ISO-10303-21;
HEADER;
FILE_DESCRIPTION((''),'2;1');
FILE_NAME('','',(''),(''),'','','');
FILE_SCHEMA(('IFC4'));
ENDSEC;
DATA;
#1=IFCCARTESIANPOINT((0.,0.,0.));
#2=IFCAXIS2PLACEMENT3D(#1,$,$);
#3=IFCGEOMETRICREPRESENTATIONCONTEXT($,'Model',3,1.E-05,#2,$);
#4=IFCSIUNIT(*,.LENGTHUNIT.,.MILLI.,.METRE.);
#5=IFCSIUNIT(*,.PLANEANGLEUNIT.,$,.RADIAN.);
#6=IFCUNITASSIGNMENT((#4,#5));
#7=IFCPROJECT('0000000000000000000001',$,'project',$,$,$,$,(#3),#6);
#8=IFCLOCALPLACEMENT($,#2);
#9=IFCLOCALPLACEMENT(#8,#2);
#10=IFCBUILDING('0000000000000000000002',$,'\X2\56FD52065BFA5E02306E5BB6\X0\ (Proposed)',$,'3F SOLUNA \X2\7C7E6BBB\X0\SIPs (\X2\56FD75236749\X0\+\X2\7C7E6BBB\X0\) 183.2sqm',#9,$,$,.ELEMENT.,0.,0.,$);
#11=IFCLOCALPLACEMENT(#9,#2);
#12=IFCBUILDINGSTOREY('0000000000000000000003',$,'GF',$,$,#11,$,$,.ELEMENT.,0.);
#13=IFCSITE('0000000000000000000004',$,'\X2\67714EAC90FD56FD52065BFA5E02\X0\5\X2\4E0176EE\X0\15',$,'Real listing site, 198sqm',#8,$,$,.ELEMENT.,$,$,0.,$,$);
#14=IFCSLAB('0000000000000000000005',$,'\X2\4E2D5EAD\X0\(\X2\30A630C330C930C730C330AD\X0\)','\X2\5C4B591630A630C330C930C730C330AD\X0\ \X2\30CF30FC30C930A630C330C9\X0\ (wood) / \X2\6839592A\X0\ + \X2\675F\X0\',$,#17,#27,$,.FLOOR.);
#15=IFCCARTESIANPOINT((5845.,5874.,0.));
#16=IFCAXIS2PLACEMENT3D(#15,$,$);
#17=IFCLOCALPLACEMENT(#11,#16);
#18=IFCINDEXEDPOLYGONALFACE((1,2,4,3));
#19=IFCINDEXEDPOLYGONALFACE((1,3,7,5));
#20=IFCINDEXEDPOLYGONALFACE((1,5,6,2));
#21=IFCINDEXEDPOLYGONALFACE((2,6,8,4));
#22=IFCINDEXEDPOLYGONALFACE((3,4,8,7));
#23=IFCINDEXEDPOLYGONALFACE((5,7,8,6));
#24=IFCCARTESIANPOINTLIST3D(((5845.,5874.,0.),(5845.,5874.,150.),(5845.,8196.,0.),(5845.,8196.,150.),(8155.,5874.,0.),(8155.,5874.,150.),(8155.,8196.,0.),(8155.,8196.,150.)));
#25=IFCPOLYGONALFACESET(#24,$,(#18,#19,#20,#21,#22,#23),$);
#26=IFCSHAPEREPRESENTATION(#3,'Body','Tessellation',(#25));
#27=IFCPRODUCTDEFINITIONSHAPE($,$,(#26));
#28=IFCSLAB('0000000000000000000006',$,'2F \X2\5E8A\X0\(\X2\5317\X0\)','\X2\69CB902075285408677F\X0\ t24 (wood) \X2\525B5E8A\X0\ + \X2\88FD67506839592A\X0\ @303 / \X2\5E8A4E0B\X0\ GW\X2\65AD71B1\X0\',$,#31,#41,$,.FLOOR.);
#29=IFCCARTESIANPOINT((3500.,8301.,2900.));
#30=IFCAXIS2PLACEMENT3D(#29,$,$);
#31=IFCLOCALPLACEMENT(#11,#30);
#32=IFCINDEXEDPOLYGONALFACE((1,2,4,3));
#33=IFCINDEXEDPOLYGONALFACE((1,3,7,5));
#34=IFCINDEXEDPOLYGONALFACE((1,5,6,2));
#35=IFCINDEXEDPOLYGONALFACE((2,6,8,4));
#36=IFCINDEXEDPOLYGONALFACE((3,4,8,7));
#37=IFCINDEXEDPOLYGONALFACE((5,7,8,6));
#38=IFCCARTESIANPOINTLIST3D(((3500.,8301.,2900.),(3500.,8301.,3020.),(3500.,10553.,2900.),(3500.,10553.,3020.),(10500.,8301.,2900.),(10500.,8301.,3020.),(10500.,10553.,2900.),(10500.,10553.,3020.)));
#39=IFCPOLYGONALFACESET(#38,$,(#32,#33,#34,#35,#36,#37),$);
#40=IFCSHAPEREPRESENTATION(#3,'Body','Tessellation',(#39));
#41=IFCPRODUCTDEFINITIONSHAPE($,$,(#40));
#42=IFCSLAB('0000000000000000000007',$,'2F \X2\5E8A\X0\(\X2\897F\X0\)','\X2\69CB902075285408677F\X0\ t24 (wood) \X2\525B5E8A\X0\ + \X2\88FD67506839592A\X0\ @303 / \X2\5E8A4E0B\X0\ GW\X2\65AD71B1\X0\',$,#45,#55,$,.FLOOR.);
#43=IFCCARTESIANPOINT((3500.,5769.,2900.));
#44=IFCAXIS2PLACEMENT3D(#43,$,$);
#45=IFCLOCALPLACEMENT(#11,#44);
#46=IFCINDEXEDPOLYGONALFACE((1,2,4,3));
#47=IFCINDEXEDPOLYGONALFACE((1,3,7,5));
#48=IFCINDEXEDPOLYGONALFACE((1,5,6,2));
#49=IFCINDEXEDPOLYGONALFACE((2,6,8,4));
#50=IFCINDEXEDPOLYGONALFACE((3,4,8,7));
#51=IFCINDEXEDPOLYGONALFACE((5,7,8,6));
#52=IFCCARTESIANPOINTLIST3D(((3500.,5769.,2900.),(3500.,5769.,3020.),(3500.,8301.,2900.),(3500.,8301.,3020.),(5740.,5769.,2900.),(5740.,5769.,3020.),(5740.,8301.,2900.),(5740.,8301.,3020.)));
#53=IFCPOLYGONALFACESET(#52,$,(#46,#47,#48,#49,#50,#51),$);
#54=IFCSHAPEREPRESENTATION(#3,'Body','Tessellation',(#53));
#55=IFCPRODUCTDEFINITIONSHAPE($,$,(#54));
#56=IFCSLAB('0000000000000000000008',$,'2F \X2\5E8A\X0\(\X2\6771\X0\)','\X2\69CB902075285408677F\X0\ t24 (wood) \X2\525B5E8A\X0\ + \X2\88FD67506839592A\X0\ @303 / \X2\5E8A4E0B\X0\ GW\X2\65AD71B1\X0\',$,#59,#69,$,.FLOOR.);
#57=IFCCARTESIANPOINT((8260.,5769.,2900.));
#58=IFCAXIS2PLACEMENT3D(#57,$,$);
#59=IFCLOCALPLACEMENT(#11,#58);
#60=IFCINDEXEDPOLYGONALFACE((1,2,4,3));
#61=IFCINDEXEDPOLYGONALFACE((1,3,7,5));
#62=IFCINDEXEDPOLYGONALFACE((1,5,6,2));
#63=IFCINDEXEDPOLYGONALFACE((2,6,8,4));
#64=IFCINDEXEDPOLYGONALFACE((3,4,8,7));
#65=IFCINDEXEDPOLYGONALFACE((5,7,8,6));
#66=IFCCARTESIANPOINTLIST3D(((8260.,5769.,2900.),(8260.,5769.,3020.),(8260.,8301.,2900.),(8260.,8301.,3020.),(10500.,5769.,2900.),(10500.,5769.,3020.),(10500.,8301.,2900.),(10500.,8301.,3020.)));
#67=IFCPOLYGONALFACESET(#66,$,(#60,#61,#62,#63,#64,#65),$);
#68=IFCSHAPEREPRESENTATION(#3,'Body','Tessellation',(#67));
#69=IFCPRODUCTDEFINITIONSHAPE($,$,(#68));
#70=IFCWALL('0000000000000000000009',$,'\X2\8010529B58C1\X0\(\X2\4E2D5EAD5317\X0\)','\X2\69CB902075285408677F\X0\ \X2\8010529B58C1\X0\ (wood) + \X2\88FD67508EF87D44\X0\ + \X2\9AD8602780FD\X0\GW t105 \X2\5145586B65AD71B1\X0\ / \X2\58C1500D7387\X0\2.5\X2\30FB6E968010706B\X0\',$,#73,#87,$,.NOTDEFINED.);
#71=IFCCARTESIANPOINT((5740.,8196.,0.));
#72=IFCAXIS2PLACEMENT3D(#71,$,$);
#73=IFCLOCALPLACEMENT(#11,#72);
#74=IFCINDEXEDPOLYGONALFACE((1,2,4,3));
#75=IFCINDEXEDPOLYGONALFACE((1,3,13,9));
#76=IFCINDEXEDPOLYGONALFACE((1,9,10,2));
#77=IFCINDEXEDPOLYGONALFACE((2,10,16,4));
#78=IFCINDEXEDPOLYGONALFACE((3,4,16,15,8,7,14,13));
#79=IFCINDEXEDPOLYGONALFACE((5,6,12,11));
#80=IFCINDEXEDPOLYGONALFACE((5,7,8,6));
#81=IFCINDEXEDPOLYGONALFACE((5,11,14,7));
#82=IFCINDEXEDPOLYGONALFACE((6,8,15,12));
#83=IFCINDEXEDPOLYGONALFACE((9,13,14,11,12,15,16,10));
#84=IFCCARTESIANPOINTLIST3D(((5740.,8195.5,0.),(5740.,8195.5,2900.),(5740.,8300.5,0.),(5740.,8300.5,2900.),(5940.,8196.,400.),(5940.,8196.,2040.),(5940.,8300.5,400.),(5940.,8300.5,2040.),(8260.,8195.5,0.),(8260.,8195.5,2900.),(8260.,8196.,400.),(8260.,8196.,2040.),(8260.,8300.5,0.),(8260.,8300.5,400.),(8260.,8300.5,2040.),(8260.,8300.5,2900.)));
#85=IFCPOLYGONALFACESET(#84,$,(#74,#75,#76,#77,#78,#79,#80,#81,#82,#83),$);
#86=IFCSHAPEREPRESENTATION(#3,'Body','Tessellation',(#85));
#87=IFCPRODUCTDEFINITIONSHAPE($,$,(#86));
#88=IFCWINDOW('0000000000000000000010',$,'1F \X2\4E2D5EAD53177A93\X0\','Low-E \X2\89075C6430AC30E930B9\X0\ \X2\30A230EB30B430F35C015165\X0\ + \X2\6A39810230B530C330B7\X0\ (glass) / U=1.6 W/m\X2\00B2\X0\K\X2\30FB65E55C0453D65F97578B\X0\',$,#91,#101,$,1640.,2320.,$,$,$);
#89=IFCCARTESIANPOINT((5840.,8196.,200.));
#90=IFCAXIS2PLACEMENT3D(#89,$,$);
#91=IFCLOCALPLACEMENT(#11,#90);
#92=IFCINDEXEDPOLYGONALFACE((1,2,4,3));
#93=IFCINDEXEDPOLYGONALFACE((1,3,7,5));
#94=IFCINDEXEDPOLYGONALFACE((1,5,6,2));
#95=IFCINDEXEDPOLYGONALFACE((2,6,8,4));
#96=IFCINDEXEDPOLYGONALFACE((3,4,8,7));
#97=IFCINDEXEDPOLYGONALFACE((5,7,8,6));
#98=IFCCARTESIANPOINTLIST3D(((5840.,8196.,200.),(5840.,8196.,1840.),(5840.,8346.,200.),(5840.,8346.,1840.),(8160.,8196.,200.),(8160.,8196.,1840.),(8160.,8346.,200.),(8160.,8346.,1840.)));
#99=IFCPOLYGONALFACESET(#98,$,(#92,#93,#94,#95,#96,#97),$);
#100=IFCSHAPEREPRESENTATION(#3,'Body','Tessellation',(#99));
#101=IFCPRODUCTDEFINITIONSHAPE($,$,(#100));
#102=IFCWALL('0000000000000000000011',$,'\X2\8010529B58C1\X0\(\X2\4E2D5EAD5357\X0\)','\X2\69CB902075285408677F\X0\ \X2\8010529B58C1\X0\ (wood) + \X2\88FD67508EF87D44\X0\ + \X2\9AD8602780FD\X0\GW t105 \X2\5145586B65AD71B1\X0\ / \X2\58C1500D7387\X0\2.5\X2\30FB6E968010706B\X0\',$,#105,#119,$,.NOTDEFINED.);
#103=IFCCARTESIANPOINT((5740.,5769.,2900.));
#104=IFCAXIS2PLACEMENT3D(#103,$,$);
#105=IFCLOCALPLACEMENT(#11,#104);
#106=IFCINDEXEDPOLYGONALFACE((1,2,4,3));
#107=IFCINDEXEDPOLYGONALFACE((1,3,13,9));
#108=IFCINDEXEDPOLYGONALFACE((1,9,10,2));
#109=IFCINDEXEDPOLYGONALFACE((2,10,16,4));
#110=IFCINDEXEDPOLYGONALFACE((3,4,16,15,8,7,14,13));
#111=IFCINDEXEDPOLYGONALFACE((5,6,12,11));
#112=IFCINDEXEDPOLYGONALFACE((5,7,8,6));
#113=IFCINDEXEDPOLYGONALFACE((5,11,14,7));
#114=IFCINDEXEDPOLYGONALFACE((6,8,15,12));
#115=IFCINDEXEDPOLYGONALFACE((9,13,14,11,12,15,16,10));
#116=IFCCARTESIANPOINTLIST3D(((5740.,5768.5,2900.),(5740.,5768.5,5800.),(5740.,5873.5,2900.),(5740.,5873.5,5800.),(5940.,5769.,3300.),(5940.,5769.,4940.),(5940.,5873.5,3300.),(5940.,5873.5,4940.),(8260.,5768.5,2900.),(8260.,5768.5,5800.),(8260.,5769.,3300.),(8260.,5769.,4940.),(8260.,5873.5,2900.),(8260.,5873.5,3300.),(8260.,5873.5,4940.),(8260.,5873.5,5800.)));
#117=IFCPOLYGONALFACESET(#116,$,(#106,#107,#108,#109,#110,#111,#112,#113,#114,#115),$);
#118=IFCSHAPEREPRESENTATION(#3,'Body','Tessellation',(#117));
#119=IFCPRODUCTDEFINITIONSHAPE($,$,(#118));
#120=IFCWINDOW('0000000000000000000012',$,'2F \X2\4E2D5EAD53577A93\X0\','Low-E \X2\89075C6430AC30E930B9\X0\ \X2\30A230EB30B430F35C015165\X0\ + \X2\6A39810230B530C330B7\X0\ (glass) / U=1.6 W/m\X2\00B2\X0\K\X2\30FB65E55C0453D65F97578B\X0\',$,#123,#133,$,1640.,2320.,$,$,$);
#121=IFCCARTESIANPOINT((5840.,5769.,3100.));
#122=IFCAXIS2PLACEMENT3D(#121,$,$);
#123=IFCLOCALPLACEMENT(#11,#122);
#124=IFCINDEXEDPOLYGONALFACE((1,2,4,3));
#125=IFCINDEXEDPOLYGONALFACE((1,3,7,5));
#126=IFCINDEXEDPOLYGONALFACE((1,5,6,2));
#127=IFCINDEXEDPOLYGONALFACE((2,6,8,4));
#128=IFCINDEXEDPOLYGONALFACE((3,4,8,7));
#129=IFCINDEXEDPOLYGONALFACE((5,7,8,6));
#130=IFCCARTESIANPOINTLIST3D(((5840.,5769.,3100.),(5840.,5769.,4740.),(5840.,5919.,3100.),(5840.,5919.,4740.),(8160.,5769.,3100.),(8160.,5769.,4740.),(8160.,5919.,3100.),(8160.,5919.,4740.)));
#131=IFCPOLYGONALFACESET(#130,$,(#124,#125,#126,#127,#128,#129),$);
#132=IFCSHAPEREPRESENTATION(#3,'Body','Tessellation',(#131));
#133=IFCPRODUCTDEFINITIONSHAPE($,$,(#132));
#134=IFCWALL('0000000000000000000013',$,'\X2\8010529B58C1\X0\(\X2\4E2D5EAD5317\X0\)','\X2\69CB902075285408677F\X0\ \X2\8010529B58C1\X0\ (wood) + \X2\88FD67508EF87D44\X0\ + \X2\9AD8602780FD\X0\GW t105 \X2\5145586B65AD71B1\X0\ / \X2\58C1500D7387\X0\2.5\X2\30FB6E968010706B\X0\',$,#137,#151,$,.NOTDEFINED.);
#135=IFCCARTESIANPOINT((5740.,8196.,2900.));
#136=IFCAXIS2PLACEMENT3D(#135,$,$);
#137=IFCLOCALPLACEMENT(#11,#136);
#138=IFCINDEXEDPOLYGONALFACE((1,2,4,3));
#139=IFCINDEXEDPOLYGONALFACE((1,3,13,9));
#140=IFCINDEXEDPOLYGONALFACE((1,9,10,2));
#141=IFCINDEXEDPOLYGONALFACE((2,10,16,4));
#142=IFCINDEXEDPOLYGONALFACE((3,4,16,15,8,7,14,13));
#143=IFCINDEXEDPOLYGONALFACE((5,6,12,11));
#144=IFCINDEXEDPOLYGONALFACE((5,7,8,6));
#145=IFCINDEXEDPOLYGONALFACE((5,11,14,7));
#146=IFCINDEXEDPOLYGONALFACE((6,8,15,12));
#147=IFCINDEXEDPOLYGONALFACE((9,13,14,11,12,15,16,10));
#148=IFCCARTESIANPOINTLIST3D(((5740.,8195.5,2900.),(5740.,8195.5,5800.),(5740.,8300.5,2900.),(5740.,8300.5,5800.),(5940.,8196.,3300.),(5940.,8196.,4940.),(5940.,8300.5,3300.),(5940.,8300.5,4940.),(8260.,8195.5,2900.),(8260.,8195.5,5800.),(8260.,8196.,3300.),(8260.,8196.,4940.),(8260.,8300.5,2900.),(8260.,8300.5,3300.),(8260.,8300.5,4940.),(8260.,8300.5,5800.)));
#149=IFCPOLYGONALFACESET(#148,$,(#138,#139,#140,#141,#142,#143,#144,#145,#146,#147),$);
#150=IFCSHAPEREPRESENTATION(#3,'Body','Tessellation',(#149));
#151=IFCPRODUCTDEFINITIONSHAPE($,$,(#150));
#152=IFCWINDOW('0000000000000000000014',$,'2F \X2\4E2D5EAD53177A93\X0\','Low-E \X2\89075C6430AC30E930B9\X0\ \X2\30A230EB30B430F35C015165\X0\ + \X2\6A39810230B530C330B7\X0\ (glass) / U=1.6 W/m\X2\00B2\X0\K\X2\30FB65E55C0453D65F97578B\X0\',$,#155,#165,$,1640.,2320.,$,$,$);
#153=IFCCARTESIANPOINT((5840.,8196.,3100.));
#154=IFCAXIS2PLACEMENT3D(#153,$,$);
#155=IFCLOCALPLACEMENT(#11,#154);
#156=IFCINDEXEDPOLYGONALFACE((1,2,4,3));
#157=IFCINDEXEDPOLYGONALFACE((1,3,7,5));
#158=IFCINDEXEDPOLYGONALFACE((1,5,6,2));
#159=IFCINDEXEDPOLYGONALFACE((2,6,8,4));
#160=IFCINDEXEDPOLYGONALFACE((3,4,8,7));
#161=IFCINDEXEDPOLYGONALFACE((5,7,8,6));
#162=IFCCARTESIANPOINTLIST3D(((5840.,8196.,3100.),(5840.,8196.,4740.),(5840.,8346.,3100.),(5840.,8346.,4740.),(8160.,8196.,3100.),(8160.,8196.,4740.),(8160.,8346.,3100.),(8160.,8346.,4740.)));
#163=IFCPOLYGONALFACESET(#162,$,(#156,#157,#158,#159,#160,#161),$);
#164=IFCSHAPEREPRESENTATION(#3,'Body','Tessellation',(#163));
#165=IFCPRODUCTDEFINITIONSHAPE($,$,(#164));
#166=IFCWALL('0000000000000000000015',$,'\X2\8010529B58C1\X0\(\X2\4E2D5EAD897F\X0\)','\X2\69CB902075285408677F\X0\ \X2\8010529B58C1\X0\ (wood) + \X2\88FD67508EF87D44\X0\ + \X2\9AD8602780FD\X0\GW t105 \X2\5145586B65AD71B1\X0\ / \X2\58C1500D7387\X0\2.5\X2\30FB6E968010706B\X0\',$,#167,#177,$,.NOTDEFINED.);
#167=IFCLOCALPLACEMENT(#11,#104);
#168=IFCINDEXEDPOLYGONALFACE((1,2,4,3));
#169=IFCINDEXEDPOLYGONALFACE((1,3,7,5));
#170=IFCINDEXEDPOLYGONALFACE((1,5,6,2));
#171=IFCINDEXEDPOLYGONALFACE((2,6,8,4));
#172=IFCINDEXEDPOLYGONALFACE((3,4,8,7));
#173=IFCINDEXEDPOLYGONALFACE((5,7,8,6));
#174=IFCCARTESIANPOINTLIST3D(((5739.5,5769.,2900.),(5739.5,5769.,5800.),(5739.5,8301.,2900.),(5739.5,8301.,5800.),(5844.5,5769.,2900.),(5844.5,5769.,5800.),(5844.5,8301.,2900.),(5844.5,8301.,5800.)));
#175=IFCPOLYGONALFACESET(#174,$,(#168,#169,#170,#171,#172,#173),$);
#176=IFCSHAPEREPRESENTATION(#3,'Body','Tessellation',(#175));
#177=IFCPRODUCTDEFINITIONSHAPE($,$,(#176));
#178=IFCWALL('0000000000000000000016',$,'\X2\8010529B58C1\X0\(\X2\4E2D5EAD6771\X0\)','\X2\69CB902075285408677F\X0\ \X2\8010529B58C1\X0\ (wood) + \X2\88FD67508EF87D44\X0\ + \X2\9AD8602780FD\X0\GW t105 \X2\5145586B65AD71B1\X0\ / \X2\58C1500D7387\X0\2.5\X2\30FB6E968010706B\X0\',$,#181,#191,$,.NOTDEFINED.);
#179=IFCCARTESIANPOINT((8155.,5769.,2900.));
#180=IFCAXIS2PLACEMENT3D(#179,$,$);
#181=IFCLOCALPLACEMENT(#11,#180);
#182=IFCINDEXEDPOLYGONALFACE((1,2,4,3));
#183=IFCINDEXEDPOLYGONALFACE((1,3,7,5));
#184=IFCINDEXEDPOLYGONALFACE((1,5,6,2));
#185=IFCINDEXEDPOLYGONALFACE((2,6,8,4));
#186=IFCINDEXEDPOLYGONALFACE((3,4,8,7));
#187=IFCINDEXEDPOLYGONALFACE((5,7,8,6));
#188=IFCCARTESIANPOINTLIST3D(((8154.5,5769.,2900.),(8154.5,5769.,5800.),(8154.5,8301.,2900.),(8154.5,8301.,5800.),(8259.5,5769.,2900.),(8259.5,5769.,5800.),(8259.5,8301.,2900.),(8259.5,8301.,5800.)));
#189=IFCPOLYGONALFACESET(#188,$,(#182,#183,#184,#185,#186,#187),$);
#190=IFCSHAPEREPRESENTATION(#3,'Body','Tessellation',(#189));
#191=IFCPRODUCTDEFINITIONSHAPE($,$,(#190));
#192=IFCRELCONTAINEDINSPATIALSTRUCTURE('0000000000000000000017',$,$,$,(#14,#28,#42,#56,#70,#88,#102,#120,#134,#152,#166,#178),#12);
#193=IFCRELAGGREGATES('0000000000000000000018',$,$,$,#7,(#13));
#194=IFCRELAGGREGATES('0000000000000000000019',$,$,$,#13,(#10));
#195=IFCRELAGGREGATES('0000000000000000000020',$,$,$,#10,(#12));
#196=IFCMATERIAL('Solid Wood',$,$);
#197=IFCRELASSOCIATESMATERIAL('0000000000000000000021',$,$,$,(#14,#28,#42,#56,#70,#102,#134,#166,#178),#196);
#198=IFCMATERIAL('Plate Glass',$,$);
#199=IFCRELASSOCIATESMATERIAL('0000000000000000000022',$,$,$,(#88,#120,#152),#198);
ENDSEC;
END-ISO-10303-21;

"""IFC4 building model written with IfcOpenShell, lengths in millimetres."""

from ifc_helpers import new_model, si_unit, frame, frame_2d, origin, place, context, project, spatial, rectangle, extrude, material, element, fill, save


model = new_model("IFC4")

# Units and contexts
model_context = context("Model", 3, precision=1e-05, world=origin())
ifc_project = project(units=[si_unit("LENGTHUNIT", "METRE", prefix="MILLI"), si_unit("PLANEANGLEUNIT", "RADIAN")], contexts=[model_context])

# Site, building, storey
site_placement = place(None, origin())
site = spatial("IfcSite", under=ifc_project, at=site_placement, Name="東京都国分寺市5丁目15", ObjectType="Real listing site, 198sqm", CompositionType="ELEMENT", RefElevation=0.0)
building_placement = place(site_placement, origin())
building = spatial("IfcBuilding", under=site, at=building_placement, Name="国分寺市の家 (Proposed)", ObjectType="3F SOLUNA 籾殻SIPs (国産杉+籾殻) 183.2sqm", CompositionType="ELEMENT", ElevationOfRefHeight=0.0, ElevationOfTerrain=0.0)
storey_placement = place(building_placement, origin())
storey = spatial("IfcBuildingStorey", under=building, at=storey_placement, Name="GF", CompositionType="ELEMENT", Elevation=0.0)

# Slabs
ifc_material_1 = material(Name="Solid Wood")
slab_1_placement = place(storey_placement, frame((5845.0, 5874.0, 0.0)))
element("IfcSlab", 1, at=slab_1_placement, inside=storey, material=ifc_material_1, Name="中庭(ウッドデッキ)", Description="屋外ウッドデッキ ハードウッド (wood) / 根太 + 束", PredefinedType="FLOOR", context=model_context, shape_type="SweptSolid", body=[
    extrude(rectangle(XDim=2310.0, YDim=2322.0, at=frame_2d((1155.0, 1161.0))), frame((5845.0, 5874.0, 0.0)), (0.0, 0.0, 1.0), 150.0),
])
slab_2_placement = place(storey_placement, frame((3500.0, 8301.0, 2900.0)))
element("IfcSlab", 2, at=slab_2_placement, inside=storey, material=ifc_material_1, Name="2F 床(北)", Description="構造用合板 t24 (wood) 剛床 + 製材根太 @303 / 床下 GW断熱", PredefinedType="FLOOR", context=model_context, shape_type="SweptSolid", body=[
    extrude(rectangle(XDim=7000.0, YDim=2252.0, at=frame_2d((3500.0, 1126.0))), frame((3500.0, 8301.0, 2900.0)), (0.0, 0.0, 1.0), 120.0),
])
slab_3_placement = place(storey_placement, frame((3500.0, 5769.0, 2900.0)))
element("IfcSlab", 3, at=slab_3_placement, inside=storey, material=ifc_material_1, Name="2F 床(西)", Description="構造用合板 t24 (wood) 剛床 + 製材根太 @303 / 床下 GW断熱", PredefinedType="FLOOR", context=model_context, shape_type="SweptSolid", body=[
    extrude(rectangle(XDim=2240.0, YDim=2532.0, at=frame_2d((1120.0, 1266.0))), frame((3500.0, 5769.0, 2900.0)), (0.0, 0.0, 1.0), 120.0),
])
slab_4_placement = place(storey_placement, frame((8260.0, 5769.0, 2900.0)))
element("IfcSlab", 4, at=slab_4_placement, inside=storey, material=ifc_material_1, Name="2F 床(東)", Description="構造用合板 t24 (wood) 剛床 + 製材根太 @303 / 床下 GW断熱", PredefinedType="FLOOR", context=model_context, shape_type="SweptSolid", body=[
    extrude(rectangle(XDim=2240.0, YDim=2532.0, at=frame_2d((1120.0, 1266.0))), frame((8260.0, 5769.0, 2900.0)), (0.0, 0.0, 1.0), 120.0),
])

# Wall, opening, window
wall_1_placement = place(storey_placement, frame((5740.0, 8196.0, 0.0)))
wall_1 = element("IfcWall", 5, at=wall_1_placement, inside=storey, material=ifc_material_1, Name="耐力壁(中庭北)", Description="構造用合板 耐力壁 (wood) + 製材軸組 + 高性能GW t105 充填断熱 / 壁倍率2.5・準耐火", PredefinedType="NOTDEFINED", context=model_context, shape_type="SweptSolid", body=[
    extrude(rectangle(XDim=2520.0, YDim=105.0, at=frame_2d((1260.0, 52.0))), frame((5740.0, 8196.0, 0.0)), (0.0, 0.0, 1.0), 2900.0),
])
opening_1_placement = place(storey_placement, frame((5840.0, 8196.0, 200.0)))
opening_1 = element("IfcOpeningElement", 6, at=opening_1_placement, cuts=wall_1, PredefinedType="NOTDEFINED", context=model_context, shape_type="SweptSolid", body=[
    extrude(rectangle(XDim=2320.0, YDim=150.0, at=frame_2d((1160.0, 75.0))), frame((5840.0, 8196.0, 200.0)), (0.0, 0.0, 1.0), 1640.0),
])
ifc_material_2 = material(Name="Plate Glass")
window_1_placement = place(storey_placement, frame((5840.0, 8196.0, 200.0)))
window_1 = element("IfcWindow", 7, at=window_1_placement, inside=storey, material=ifc_material_2, Name="1F 中庭北窓", Description="Low-E 複層ガラス アルゴン封入 + 樹脂サッシ (glass) / U=1.6 W/m²K・日射取得型", OverallHeight=1640.0, OverallWidth=2320.0, context=model_context, shape_type="SweptSolid", body=[
    extrude(rectangle(XDim=2320.0, YDim=150.0, at=frame_2d((1160.0, 75.0))), frame((5840.0, 8196.0, 200.0)), (0.0, 0.0, 1.0), 1640.0),
])
fill(opening_1, window_1)

# Walls, openings, windows
wall_2_placement = place(storey_placement, frame((5740.0, 5769.0, 2900.0)))
wall_2 = element("IfcWall", 8, at=wall_2_placement, inside=storey, material=ifc_material_1, Name="耐力壁(中庭南)", Description="構造用合板 耐力壁 (wood) + 製材軸組 + 高性能GW t105 充填断熱 / 壁倍率2.5・準耐火", PredefinedType="NOTDEFINED", context=model_context, shape_type="SweptSolid", body=[
    extrude(rectangle(XDim=2520.0, YDim=105.0, at=frame_2d((1260.0, 52.0))), frame((5740.0, 5769.0, 2900.0)), (0.0, 0.0, 1.0), 2900.0),
])
opening_2_placement = place(storey_placement, frame((5840.0, 5769.0, 3100.0)))
opening_2 = element("IfcOpeningElement", 9, at=opening_2_placement, cuts=wall_2, PredefinedType="NOTDEFINED", context=model_context, shape_type="SweptSolid", body=[
    extrude(rectangle(XDim=2320.0, YDim=150.0, at=frame_2d((1160.0, 75.0))), frame((5840.0, 5769.0, 3100.0)), (0.0, 0.0, 1.0), 1640.0),
])
window_2_placement = place(storey_placement, frame((5840.0, 5769.0, 3100.0)))
window_2 = element("IfcWindow", 10, at=window_2_placement, inside=storey, material=ifc_material_2, Name="2F 中庭南窓", Description="Low-E 複層ガラス アルゴン封入 + 樹脂サッシ (glass) / U=1.6 W/m²K・日射取得型", OverallHeight=1640.0, OverallWidth=2320.0, context=model_context, shape_type="SweptSolid", body=[
    extrude(rectangle(XDim=2320.0, YDim=150.0, at=frame_2d((1160.0, 75.0))), frame((5840.0, 5769.0, 3100.0)), (0.0, 0.0, 1.0), 1640.0),
])
fill(opening_2, window_2)
wall_3_placement = place(storey_placement, frame((5740.0, 8196.0, 2900.0)))
wall_3 = element("IfcWall", 11, at=wall_3_placement, inside=storey, material=ifc_material_1, Name="耐力壁(中庭北)", Description="構造用合板 耐力壁 (wood) + 製材軸組 + 高性能GW t105 充填断熱 / 壁倍率2.5・準耐火", PredefinedType="NOTDEFINED", context=model_context, shape_type="SweptSolid", body=[
    extrude(rectangle(XDim=2520.0, YDim=105.0, at=frame_2d((1260.0, 52.0))), frame((5740.0, 8196.0, 2900.0)), (0.0, 0.0, 1.0), 2900.0),
])
opening_3_placement = place(storey_placement, frame((5840.0, 8196.0, 3100.0)))
opening_3 = element("IfcOpeningElement", 12, at=opening_3_placement, cuts=wall_3, PredefinedType="NOTDEFINED", context=model_context, shape_type="SweptSolid", body=[
    extrude(rectangle(XDim=2320.0, YDim=150.0, at=frame_2d((1160.0, 75.0))), frame((5840.0, 8196.0, 3100.0)), (0.0, 0.0, 1.0), 1640.0),
])
window_3_placement = place(storey_placement, frame((5840.0, 8196.0, 3100.0)))
window_3 = element("IfcWindow", 13, at=window_3_placement, inside=storey, material=ifc_material_2, Name="2F 中庭北窓", Description="Low-E 複層ガラス アルゴン封入 + 樹脂サッシ (glass) / U=1.6 W/m²K・日射取得型", OverallHeight=1640.0, OverallWidth=2320.0, context=model_context, shape_type="SweptSolid", body=[
    extrude(rectangle(XDim=2320.0, YDim=150.0, at=frame_2d((1160.0, 75.0))), frame((5840.0, 8196.0, 3100.0)), (0.0, 0.0, 1.0), 1640.0),
])
fill(opening_3, window_3)

# Walls
wall_4_placement = place(storey_placement, frame((5740.0, 5769.0, 2900.0)))
element("IfcWall", 14, at=wall_4_placement, inside=storey, material=ifc_material_1, Name="耐力壁(中庭西)", Description="構造用合板 耐力壁 (wood) + 製材軸組 + 高性能GW t105 充填断熱 / 壁倍率2.5・準耐火", PredefinedType="NOTDEFINED", context=model_context, shape_type="SweptSolid", body=[
    extrude(rectangle(XDim=105.0, YDim=2532.0, at=frame_2d((52.0, 1266.0))), frame((5740.0, 5769.0, 2900.0)), (0.0, 0.0, 1.0), 2900.0),
])
wall_5_placement = place(storey_placement, frame((8155.0, 5769.0, 2900.0)))
element("IfcWall", 15, at=wall_5_placement, inside=storey, material=ifc_material_1, Name="耐力壁(中庭東)", Description="構造用合板 耐力壁 (wood) + 製材軸組 + 高性能GW t105 充填断熱 / 壁倍率2.5・準耐火", PredefinedType="NOTDEFINED", context=model_context, shape_type="SweptSolid", body=[
    extrude(rectangle(XDim=105.0, YDim=2532.0, at=frame_2d((52.0, 1266.0))), frame((8155.0, 5769.0, 2900.0)), (0.0, 0.0, 1.0), 2900.0),
])

save(model, "model.ifc")
